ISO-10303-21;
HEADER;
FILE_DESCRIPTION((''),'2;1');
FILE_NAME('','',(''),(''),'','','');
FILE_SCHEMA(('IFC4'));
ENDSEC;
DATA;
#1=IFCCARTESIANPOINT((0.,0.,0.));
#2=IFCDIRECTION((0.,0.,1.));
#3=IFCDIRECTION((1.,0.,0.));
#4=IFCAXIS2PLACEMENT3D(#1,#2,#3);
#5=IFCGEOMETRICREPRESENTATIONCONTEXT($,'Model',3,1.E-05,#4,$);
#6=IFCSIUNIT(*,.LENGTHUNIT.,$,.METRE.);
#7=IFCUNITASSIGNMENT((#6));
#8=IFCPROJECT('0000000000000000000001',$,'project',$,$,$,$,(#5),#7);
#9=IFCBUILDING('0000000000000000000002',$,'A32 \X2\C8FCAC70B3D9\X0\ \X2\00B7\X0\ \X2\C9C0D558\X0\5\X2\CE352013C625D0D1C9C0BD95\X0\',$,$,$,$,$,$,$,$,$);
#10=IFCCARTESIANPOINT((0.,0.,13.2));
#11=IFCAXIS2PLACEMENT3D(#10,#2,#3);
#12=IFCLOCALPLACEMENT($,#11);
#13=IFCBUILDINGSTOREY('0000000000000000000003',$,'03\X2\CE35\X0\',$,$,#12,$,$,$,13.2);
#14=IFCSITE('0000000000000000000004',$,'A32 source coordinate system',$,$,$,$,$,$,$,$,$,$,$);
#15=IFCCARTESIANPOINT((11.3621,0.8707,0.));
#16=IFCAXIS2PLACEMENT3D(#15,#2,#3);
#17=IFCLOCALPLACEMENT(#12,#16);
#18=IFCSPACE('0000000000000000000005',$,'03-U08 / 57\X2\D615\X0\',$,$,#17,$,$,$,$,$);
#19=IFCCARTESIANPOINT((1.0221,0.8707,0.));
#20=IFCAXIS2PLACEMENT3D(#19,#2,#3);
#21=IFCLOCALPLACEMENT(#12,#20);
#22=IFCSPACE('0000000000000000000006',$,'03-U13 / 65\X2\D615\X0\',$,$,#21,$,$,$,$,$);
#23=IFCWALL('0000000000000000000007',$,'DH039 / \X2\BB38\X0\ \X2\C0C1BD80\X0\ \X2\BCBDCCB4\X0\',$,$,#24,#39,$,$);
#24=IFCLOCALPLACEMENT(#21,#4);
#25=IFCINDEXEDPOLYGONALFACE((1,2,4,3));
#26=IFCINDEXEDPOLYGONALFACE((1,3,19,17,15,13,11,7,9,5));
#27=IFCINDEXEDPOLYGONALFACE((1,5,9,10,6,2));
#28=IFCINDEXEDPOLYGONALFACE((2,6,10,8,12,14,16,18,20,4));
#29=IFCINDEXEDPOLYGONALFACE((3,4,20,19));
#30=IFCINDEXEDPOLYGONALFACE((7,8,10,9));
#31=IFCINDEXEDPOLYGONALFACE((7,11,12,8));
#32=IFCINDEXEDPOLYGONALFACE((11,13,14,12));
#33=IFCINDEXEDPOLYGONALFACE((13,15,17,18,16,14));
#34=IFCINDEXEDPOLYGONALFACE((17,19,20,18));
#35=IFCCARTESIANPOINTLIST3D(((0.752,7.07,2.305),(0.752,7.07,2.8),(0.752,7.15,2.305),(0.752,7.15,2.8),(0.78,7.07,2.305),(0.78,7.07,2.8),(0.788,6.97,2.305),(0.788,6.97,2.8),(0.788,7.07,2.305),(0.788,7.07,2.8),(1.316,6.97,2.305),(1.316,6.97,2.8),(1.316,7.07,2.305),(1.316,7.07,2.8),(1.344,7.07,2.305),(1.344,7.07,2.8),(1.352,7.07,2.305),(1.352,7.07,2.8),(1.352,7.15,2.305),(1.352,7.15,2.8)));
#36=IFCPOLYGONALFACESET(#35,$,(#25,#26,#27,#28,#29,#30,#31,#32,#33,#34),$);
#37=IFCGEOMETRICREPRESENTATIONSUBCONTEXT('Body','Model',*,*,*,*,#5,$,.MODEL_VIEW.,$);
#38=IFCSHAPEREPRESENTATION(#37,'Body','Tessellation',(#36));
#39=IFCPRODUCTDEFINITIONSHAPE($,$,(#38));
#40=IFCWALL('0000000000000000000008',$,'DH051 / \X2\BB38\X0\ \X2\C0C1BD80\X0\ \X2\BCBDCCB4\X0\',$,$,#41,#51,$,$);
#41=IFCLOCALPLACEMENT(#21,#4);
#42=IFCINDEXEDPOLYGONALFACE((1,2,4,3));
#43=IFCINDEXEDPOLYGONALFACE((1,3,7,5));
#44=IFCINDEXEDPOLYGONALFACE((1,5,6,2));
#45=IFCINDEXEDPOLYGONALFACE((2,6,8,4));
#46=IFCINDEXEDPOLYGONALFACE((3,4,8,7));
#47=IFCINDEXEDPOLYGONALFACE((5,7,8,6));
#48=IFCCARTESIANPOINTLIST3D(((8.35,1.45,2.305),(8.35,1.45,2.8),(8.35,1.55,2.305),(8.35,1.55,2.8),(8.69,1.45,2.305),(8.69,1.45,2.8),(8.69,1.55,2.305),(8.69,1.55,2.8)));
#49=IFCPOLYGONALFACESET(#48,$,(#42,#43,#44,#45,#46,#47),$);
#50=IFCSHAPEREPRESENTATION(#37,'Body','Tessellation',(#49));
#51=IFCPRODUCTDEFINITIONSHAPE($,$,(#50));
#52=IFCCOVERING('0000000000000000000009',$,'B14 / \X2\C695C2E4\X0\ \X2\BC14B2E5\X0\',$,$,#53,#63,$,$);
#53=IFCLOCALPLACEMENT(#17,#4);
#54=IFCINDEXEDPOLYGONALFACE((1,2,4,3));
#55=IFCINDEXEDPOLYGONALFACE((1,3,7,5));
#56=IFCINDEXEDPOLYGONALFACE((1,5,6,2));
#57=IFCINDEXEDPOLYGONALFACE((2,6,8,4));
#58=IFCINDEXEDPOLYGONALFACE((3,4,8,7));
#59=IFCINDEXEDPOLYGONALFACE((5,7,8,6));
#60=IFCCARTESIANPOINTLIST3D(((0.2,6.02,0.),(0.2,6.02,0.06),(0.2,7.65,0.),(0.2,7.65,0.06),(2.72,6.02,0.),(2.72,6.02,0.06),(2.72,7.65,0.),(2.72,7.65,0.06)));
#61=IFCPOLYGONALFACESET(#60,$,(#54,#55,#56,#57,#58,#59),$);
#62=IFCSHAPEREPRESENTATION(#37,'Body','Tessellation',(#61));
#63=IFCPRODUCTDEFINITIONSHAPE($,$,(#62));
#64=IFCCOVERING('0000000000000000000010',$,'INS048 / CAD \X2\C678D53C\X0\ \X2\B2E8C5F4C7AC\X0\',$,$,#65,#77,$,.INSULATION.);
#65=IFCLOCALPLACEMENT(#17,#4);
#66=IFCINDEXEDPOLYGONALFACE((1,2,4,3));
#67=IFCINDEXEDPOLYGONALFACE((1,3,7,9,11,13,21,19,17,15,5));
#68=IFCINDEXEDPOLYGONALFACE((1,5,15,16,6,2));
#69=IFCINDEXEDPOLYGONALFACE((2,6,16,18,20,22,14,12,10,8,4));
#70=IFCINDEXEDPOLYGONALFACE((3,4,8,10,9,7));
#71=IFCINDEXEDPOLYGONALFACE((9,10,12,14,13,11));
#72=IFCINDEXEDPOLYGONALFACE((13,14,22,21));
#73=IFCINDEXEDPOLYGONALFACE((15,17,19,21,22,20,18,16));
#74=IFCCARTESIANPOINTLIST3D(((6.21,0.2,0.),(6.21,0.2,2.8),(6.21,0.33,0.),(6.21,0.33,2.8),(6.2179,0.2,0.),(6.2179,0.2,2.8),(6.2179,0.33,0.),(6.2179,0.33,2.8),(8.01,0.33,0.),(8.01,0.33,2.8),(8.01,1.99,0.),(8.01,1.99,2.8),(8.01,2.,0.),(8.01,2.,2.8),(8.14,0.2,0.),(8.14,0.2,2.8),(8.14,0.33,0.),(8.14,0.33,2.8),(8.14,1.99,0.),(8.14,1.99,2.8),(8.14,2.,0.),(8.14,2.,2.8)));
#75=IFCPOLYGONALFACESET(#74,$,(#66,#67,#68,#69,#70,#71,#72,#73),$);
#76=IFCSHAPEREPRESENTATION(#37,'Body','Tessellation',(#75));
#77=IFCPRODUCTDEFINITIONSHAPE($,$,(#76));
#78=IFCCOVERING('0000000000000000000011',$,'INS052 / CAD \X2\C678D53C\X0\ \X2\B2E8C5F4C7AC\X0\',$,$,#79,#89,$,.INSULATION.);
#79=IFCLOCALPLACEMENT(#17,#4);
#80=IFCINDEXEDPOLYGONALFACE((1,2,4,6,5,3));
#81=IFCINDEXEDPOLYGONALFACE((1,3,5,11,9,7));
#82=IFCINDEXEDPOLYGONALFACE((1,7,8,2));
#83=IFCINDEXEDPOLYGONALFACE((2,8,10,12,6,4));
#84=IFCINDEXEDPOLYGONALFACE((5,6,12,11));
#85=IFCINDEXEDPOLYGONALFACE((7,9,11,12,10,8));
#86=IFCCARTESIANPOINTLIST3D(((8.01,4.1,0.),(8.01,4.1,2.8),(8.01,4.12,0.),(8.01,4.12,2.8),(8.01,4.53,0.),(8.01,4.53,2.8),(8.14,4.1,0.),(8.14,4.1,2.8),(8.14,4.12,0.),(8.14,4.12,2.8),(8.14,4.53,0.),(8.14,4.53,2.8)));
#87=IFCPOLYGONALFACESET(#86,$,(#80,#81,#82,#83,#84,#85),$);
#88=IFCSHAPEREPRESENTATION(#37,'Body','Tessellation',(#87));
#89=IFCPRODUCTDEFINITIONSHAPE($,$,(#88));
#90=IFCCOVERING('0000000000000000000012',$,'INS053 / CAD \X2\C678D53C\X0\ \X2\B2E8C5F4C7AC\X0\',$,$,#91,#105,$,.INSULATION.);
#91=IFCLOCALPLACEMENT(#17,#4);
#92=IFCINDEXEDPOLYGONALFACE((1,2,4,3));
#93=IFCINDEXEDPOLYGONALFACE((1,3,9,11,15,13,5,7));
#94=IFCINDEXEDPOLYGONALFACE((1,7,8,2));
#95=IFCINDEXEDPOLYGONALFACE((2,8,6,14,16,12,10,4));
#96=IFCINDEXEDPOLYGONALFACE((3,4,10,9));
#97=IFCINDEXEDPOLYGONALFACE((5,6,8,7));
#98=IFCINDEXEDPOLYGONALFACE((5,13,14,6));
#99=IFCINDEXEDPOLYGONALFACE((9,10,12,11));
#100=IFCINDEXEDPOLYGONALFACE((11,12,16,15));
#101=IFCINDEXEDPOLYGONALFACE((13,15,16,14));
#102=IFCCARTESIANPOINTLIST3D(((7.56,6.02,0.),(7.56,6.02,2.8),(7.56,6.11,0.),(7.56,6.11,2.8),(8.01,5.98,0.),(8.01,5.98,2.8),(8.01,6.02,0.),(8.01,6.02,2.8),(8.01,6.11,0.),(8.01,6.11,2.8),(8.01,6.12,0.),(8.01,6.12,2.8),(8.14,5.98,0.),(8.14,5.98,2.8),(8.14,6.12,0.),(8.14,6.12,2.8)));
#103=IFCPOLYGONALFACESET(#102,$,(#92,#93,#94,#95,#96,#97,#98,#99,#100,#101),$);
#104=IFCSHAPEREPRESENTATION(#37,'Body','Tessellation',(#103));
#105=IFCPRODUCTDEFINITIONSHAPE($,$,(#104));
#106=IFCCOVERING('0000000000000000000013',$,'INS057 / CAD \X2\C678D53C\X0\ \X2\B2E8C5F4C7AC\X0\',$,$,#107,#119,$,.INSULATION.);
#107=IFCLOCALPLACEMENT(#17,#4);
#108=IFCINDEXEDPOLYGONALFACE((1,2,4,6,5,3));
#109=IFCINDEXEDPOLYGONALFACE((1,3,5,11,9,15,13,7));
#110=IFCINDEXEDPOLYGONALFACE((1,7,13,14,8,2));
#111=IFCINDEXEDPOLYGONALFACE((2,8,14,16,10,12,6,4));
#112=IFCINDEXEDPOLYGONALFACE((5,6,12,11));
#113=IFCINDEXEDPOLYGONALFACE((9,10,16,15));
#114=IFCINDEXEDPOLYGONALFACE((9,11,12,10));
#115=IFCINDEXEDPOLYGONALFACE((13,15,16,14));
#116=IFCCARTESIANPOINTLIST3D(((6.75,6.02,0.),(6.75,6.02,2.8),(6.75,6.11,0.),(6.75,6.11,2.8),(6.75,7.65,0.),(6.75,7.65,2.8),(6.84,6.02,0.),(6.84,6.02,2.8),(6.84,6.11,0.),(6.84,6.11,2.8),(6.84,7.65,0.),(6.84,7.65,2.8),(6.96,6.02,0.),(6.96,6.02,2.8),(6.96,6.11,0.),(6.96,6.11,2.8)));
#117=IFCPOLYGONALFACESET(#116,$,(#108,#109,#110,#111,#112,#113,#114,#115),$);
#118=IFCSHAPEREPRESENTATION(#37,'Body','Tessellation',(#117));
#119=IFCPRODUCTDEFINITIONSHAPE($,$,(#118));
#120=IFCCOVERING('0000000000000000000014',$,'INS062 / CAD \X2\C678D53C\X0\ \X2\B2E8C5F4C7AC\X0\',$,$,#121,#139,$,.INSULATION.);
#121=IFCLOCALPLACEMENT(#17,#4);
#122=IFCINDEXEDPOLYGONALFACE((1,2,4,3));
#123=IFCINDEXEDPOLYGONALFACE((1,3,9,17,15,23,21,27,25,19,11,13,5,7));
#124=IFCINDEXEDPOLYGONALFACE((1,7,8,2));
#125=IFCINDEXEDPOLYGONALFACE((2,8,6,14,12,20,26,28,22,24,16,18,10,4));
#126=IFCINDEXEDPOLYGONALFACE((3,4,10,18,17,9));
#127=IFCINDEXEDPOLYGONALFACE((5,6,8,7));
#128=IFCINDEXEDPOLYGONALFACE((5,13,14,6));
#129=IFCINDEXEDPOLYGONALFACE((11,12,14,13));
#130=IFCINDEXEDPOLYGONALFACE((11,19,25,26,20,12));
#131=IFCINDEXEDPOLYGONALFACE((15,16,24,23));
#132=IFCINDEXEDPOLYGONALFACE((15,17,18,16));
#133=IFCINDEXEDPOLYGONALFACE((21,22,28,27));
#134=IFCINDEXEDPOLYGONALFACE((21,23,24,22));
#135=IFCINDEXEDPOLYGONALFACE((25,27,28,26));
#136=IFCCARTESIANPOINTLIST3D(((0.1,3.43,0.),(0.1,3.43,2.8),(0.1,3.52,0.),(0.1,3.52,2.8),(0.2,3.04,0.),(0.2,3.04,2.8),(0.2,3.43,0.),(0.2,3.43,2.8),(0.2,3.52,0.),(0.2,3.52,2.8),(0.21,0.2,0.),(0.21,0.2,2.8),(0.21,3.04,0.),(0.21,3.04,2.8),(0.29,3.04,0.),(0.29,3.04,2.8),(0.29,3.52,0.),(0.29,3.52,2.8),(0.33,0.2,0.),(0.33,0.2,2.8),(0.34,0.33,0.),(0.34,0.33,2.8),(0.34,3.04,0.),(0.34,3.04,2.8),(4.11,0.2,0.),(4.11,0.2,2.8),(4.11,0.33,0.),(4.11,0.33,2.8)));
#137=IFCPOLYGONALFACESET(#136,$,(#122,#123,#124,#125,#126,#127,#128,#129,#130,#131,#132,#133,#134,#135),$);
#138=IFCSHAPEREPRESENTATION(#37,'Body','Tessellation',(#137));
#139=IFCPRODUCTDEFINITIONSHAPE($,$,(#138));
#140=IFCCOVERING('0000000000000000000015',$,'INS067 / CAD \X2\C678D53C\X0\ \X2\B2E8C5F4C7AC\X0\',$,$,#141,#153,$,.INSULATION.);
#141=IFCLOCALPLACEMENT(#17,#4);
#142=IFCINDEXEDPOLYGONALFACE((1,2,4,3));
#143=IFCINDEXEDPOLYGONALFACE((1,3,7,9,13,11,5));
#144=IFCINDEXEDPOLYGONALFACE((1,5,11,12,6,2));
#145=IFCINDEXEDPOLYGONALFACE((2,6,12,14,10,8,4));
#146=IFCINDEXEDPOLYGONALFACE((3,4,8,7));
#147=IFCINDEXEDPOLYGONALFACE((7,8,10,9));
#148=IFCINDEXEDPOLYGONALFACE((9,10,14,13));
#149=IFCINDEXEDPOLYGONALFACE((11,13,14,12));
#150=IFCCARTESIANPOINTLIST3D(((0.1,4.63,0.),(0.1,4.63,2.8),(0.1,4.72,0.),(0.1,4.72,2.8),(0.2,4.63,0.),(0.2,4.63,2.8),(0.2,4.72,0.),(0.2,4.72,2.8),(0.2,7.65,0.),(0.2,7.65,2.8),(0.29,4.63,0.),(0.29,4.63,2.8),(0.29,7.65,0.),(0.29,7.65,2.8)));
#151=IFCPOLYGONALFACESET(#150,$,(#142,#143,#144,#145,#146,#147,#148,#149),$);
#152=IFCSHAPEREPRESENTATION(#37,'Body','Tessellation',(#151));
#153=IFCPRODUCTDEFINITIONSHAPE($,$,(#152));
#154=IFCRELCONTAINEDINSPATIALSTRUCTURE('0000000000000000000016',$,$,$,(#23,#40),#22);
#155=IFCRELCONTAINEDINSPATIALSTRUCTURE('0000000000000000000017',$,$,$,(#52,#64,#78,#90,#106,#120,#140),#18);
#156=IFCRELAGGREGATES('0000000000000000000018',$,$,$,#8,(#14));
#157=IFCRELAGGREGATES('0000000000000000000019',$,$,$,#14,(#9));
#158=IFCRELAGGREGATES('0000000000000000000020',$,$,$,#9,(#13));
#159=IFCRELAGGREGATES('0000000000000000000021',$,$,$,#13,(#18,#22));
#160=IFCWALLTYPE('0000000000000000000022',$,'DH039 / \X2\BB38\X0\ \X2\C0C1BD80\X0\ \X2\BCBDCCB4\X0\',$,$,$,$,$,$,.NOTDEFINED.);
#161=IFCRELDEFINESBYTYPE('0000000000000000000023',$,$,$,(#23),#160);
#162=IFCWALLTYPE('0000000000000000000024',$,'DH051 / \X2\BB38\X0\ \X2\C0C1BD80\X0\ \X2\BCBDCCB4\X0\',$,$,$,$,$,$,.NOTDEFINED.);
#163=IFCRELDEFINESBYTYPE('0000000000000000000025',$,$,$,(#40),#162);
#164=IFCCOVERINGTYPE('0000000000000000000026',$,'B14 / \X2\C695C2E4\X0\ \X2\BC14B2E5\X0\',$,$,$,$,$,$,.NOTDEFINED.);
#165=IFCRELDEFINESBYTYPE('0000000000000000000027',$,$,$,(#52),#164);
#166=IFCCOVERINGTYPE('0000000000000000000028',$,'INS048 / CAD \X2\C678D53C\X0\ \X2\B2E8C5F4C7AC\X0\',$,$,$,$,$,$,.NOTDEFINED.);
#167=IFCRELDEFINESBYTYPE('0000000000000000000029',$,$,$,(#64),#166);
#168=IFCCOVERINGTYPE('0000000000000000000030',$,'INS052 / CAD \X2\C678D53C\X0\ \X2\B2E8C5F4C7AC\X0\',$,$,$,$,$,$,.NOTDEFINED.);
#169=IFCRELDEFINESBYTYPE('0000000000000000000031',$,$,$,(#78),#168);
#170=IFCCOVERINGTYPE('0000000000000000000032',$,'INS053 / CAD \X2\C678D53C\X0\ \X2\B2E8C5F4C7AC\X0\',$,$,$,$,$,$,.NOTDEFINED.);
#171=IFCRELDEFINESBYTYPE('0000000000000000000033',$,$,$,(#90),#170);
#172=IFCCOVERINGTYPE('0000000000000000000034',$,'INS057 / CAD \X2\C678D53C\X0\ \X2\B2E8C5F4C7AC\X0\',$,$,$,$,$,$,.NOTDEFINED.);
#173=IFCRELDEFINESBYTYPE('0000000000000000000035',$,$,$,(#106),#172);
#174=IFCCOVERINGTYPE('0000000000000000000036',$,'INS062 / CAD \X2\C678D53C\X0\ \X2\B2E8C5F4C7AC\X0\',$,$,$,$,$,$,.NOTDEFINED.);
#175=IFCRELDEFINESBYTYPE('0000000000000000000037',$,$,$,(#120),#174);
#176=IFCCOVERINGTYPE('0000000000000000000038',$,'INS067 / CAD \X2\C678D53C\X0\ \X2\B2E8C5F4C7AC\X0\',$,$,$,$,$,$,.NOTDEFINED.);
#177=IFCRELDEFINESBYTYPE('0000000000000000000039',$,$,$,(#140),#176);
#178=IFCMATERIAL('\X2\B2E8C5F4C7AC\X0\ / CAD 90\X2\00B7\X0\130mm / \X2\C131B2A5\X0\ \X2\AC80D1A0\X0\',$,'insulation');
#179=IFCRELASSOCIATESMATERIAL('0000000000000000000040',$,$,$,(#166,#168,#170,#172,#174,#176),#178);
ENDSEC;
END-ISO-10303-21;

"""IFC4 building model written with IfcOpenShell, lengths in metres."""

from ifc_helpers import new_model, si_unit, frame, origin, origin_with_axes, place, context, subcontext, project, spatial, polyline, outline, extrude, source, transform, mapped, material, type_object, type_shapes, element, save


model = new_model("IFC4")

# Units and contexts
model_context = context("Model", 3, precision=1e-05, world=origin_with_axes())
body_context = subcontext(model_context, "Body", "Model", "MODEL_VIEW")
ifc_project = project(units=[si_unit("LENGTHUNIT", "METRE")], contexts=[model_context])

# Site, building, storey, space
storey_placement = place(None, frame((0.0, 0.0, 13.2), z_axis=(0.0, 0.0, 1.0), x_axis=(1.0, 0.0, 0.0)))
space_1_placement = place(storey_placement, frame((11.3621, 0.8707, 0.0), z_axis=(0.0, 0.0, 1.0), x_axis=(1.0, 0.0, 0.0)))
site = spatial("IfcSite", under=ifc_project, Name="A32 source coordinate system")
building = spatial("IfcBuilding", under=site, Name="A32 주거동 · 지하5층–옥탑지붕")
storey = spatial("IfcBuildingStorey", under=building, at=storey_placement, Name="03층", Elevation=13.2)
space_1 = spatial("IfcSpace", under=storey, at=space_1_placement, Name="03-U08 / 57형")

# Shared definitions
space_2_placement = place(storey_placement, frame((1.0221, 0.8707, 0.0), z_axis=(0.0, 0.0, 1.0), x_axis=(1.0, 0.0, 0.0)))
space_2 = spatial("IfcSpace", under=storey, at=space_2_placement, Name="03-U13 / 65형")

# Walls
wall_type_1 = type_object("IfcWallType", Name="DH039 / 문 상부 벽체", PredefinedType="NOTDEFINED")
shared_shape_1 = source(origin(), body_context, "Body", "SweptSolid", [
    extrude(outline(polyline([(1.316, 7.07), (1.316, 6.97), (0.788, 6.97), (0.788, 7.07), (0.78, 7.07), (0.752, 7.07), (0.752, 7.15), (1.352, 7.15), (1.352, 7.07), (1.344, 7.07), (1.316, 7.07)])), frame((0.0, 0.0, 2.305)), (0.0, 0.0, 1.0), 0.495),
])
type_shapes(wall_type_1, [shared_shape_1])
wall_1_placement = place(space_2_placement, origin_with_axes())
element("IfcWall", 1, at=wall_1_placement, inside=space_2, type_object=wall_type_1, Name="DH039 / 문 상부 벽체", context=body_context, shape_type="MappedRepresentation", body=[
    mapped(shared_shape_1, transform((0.0, 0.0, 0.0), scale=1.0)),
])
wall_type_2 = type_object("IfcWallType", Name="DH051 / 문 상부 벽체", PredefinedType="NOTDEFINED")
shared_shape_2 = source(origin(), body_context, "Body", "SweptSolid", [
    extrude(outline(polyline([(8.69, 1.55), (8.69, 1.45), (8.35, 1.45), (8.35, 1.55), (8.69, 1.55)])), frame((0.0, 0.0, 2.305)), (0.0, 0.0, 1.0), 0.495),
])
type_shapes(wall_type_2, [shared_shape_2])
wall_2_placement = place(space_2_placement, origin_with_axes())
element("IfcWall", 2, at=wall_2_placement, inside=space_2, type_object=wall_type_2, Name="DH051 / 문 상부 벽체", context=body_context, shape_type="MappedRepresentation", body=[
    mapped(shared_shape_2, transform((0.0, 0.0, 0.0), scale=1.0)),
])

# Coverings
covering_type_1 = type_object("IfcCoveringType", Name="B14 / 욕실 바닥", PredefinedType="NOTDEFINED")
shared_shape_3 = source(origin(), body_context, "Body", "SweptSolid", [
    extrude(outline(polyline([(0.2, 7.65), (2.72, 7.65), (2.72, 6.02), (0.2, 6.02), (0.2, 7.65)])), origin(), (0.0, 0.0, 1.0), 0.06),
])
type_shapes(covering_type_1, [shared_shape_3])
covering_1_placement = place(space_1_placement, origin_with_axes())
element("IfcCovering", 3, at=covering_1_placement, inside=space_1, type_object=covering_type_1, Name="B14 / 욕실 바닥", context=body_context, shape_type="MappedRepresentation", body=[
    mapped(shared_shape_3, transform((0.0, 0.0, 0.0), scale=1.0)),
])
ifc_material = material(Name="단열재 / CAD 90·130mm / 성능 검토", Category="insulation")
covering_type_2 = type_object("IfcCoveringType", Name="INS048 / CAD 외피 단열재", PredefinedType="NOTDEFINED", material=ifc_material)
shared_shape_4 = source(origin(), body_context, "Body", "SweptSolid", [
    extrude(outline(polyline([(8.01, 1.99), (8.01, 2.0), (8.14, 2.0), (8.14, 1.99), (8.14, 0.33), (8.14, 0.2), (6.2179, 0.2), (6.21, 0.2), (6.21, 0.33), (6.2179, 0.33), (8.01, 0.33), (8.01, 1.99)])), origin(), (0.0, 0.0, 1.0), 2.8),
])
type_shapes(covering_type_2, [shared_shape_4])
covering_2_placement = place(space_1_placement, origin_with_axes())
element("IfcCovering", 4, at=covering_2_placement, inside=space_1, type_object=covering_type_2, Name="INS048 / CAD 외피 단열재", PredefinedType="INSULATION", context=body_context, shape_type="MappedRepresentation", body=[
    mapped(shared_shape_4, transform((0.0, 0.0, 0.0), scale=1.0)),
])
covering_type_3 = type_object("IfcCoveringType", Name="INS052 / CAD 외피 단열재", PredefinedType="NOTDEFINED", material=ifc_material)
shared_shape_5 = source(origin(), body_context, "Body", "SweptSolid", [
    extrude(outline(polyline([(8.14, 4.1), (8.01, 4.1), (8.01, 4.12), (8.01, 4.53), (8.14, 4.53), (8.14, 4.12), (8.14, 4.1)])), origin(), (0.0, 0.0, 1.0), 2.8),
])
type_shapes(covering_type_3, [shared_shape_5])
covering_3_placement = place(space_1_placement, origin_with_axes())
element("IfcCovering", 5, at=covering_3_placement, inside=space_1, type_object=covering_type_3, Name="INS052 / CAD 외피 단열재", PredefinedType="INSULATION", context=body_context, shape_type="MappedRepresentation", body=[
    mapped(shared_shape_5, transform((0.0, 0.0, 0.0), scale=1.0)),
])
covering_type_4 = type_object("IfcCoveringType", Name="INS053 / CAD 외피 단열재", PredefinedType="NOTDEFINED", material=ifc_material)
shared_shape_6 = source(origin(), body_context, "Body", "SweptSolid", [
    extrude(outline(polyline([(8.01, 6.12), (8.14, 6.12), (8.14, 5.98), (8.01, 5.98), (8.01, 6.02), (7.56, 6.02), (7.56, 6.11), (8.01, 6.11), (8.01, 6.12)])), origin(), (0.0, 0.0, 1.0), 2.8),
])
type_shapes(covering_type_4, [shared_shape_6])
covering_4_placement = place(space_1_placement, origin_with_axes())
element("IfcCovering", 6, at=covering_4_placement, inside=space_1, type_object=covering_type_4, Name="INS053 / CAD 외피 단열재", PredefinedType="INSULATION", context=body_context, shape_type="MappedRepresentation", body=[
    mapped(shared_shape_6, transform((0.0, 0.0, 0.0), scale=1.0)),
])
covering_type_5 = type_object("IfcCoveringType", Name="INS057 / CAD 외피 단열재", PredefinedType="NOTDEFINED", material=ifc_material)
shared_shape_7 = source(origin(), body_context, "Body", "SweptSolid", [
    extrude(outline(polyline([(6.84, 6.11), (6.96, 6.11), (6.96, 6.02), (6.84, 6.02), (6.75, 6.02), (6.75, 6.11), (6.75, 7.65), (6.84, 7.65), (6.84, 6.11)])), origin(), (0.0, 0.0, 1.0), 2.8),
])
type_shapes(covering_type_5, [shared_shape_7])
covering_5_placement = place(space_1_placement, origin_with_axes())
element("IfcCovering", 7, at=covering_5_placement, inside=space_1, type_object=covering_type_5, Name="INS057 / CAD 외피 단열재", PredefinedType="INSULATION", context=body_context, shape_type="MappedRepresentation", body=[
    mapped(shared_shape_7, transform((0.0, 0.0, 0.0), scale=1.0)),
])
covering_type_6 = type_object("IfcCoveringType", Name="INS062 / CAD 외피 단열재", PredefinedType="NOTDEFINED", material=ifc_material)
shared_shape_8 = source(origin(), body_context, "Body", "SweptSolid", [
    extrude(outline(polyline([(4.11, 0.2), (0.33, 0.2), (0.21, 0.2), (0.21, 3.04), (0.2, 3.04), (0.2, 3.43), (0.1, 3.43), (0.1, 3.52), (0.2, 3.52), (0.29, 3.52), (0.29, 3.04), (0.34, 3.04), (0.34, 0.33), (4.11, 0.33), (4.11, 0.2)])), origin(), (0.0, 0.0, 1.0), 2.8),
])
type_shapes(covering_type_6, [shared_shape_8])
covering_6_placement = place(space_1_placement, origin_with_axes())
element("IfcCovering", 8, at=covering_6_placement, inside=space_1, type_object=covering_type_6, Name="INS062 / CAD 외피 단열재", PredefinedType="INSULATION", context=body_context, shape_type="MappedRepresentation", body=[
    mapped(shared_shape_8, transform((0.0, 0.0, 0.0), scale=1.0)),
])
covering_type_7 = type_object("IfcCoveringType", Name="INS067 / CAD 외피 단열재", PredefinedType="NOTDEFINED", material=ifc_material)
shared_shape_9 = source(origin(), body_context, "Body", "SweptSolid", [
    extrude(outline(polyline([(0.1, 4.72), (0.2, 4.72), (0.2, 7.65), (0.29, 7.65), (0.29, 4.63), (0.2, 4.63), (0.1, 4.63), (0.1, 4.72)])), origin(), (0.0, 0.0, 1.0), 2.8),
])
type_shapes(covering_type_7, [shared_shape_9])
covering_7_placement = place(space_1_placement, origin_with_axes())
element("IfcCovering", 9, at=covering_7_placement, inside=space_1, type_object=covering_type_7, Name="INS067 / CAD 외피 단열재", PredefinedType="INSULATION", context=body_context, shape_type="MappedRepresentation", body=[
    mapped(shared_shape_9, transform((0.0, 0.0, 0.0), scale=1.0)),
])

save(model, "model.ifc")
